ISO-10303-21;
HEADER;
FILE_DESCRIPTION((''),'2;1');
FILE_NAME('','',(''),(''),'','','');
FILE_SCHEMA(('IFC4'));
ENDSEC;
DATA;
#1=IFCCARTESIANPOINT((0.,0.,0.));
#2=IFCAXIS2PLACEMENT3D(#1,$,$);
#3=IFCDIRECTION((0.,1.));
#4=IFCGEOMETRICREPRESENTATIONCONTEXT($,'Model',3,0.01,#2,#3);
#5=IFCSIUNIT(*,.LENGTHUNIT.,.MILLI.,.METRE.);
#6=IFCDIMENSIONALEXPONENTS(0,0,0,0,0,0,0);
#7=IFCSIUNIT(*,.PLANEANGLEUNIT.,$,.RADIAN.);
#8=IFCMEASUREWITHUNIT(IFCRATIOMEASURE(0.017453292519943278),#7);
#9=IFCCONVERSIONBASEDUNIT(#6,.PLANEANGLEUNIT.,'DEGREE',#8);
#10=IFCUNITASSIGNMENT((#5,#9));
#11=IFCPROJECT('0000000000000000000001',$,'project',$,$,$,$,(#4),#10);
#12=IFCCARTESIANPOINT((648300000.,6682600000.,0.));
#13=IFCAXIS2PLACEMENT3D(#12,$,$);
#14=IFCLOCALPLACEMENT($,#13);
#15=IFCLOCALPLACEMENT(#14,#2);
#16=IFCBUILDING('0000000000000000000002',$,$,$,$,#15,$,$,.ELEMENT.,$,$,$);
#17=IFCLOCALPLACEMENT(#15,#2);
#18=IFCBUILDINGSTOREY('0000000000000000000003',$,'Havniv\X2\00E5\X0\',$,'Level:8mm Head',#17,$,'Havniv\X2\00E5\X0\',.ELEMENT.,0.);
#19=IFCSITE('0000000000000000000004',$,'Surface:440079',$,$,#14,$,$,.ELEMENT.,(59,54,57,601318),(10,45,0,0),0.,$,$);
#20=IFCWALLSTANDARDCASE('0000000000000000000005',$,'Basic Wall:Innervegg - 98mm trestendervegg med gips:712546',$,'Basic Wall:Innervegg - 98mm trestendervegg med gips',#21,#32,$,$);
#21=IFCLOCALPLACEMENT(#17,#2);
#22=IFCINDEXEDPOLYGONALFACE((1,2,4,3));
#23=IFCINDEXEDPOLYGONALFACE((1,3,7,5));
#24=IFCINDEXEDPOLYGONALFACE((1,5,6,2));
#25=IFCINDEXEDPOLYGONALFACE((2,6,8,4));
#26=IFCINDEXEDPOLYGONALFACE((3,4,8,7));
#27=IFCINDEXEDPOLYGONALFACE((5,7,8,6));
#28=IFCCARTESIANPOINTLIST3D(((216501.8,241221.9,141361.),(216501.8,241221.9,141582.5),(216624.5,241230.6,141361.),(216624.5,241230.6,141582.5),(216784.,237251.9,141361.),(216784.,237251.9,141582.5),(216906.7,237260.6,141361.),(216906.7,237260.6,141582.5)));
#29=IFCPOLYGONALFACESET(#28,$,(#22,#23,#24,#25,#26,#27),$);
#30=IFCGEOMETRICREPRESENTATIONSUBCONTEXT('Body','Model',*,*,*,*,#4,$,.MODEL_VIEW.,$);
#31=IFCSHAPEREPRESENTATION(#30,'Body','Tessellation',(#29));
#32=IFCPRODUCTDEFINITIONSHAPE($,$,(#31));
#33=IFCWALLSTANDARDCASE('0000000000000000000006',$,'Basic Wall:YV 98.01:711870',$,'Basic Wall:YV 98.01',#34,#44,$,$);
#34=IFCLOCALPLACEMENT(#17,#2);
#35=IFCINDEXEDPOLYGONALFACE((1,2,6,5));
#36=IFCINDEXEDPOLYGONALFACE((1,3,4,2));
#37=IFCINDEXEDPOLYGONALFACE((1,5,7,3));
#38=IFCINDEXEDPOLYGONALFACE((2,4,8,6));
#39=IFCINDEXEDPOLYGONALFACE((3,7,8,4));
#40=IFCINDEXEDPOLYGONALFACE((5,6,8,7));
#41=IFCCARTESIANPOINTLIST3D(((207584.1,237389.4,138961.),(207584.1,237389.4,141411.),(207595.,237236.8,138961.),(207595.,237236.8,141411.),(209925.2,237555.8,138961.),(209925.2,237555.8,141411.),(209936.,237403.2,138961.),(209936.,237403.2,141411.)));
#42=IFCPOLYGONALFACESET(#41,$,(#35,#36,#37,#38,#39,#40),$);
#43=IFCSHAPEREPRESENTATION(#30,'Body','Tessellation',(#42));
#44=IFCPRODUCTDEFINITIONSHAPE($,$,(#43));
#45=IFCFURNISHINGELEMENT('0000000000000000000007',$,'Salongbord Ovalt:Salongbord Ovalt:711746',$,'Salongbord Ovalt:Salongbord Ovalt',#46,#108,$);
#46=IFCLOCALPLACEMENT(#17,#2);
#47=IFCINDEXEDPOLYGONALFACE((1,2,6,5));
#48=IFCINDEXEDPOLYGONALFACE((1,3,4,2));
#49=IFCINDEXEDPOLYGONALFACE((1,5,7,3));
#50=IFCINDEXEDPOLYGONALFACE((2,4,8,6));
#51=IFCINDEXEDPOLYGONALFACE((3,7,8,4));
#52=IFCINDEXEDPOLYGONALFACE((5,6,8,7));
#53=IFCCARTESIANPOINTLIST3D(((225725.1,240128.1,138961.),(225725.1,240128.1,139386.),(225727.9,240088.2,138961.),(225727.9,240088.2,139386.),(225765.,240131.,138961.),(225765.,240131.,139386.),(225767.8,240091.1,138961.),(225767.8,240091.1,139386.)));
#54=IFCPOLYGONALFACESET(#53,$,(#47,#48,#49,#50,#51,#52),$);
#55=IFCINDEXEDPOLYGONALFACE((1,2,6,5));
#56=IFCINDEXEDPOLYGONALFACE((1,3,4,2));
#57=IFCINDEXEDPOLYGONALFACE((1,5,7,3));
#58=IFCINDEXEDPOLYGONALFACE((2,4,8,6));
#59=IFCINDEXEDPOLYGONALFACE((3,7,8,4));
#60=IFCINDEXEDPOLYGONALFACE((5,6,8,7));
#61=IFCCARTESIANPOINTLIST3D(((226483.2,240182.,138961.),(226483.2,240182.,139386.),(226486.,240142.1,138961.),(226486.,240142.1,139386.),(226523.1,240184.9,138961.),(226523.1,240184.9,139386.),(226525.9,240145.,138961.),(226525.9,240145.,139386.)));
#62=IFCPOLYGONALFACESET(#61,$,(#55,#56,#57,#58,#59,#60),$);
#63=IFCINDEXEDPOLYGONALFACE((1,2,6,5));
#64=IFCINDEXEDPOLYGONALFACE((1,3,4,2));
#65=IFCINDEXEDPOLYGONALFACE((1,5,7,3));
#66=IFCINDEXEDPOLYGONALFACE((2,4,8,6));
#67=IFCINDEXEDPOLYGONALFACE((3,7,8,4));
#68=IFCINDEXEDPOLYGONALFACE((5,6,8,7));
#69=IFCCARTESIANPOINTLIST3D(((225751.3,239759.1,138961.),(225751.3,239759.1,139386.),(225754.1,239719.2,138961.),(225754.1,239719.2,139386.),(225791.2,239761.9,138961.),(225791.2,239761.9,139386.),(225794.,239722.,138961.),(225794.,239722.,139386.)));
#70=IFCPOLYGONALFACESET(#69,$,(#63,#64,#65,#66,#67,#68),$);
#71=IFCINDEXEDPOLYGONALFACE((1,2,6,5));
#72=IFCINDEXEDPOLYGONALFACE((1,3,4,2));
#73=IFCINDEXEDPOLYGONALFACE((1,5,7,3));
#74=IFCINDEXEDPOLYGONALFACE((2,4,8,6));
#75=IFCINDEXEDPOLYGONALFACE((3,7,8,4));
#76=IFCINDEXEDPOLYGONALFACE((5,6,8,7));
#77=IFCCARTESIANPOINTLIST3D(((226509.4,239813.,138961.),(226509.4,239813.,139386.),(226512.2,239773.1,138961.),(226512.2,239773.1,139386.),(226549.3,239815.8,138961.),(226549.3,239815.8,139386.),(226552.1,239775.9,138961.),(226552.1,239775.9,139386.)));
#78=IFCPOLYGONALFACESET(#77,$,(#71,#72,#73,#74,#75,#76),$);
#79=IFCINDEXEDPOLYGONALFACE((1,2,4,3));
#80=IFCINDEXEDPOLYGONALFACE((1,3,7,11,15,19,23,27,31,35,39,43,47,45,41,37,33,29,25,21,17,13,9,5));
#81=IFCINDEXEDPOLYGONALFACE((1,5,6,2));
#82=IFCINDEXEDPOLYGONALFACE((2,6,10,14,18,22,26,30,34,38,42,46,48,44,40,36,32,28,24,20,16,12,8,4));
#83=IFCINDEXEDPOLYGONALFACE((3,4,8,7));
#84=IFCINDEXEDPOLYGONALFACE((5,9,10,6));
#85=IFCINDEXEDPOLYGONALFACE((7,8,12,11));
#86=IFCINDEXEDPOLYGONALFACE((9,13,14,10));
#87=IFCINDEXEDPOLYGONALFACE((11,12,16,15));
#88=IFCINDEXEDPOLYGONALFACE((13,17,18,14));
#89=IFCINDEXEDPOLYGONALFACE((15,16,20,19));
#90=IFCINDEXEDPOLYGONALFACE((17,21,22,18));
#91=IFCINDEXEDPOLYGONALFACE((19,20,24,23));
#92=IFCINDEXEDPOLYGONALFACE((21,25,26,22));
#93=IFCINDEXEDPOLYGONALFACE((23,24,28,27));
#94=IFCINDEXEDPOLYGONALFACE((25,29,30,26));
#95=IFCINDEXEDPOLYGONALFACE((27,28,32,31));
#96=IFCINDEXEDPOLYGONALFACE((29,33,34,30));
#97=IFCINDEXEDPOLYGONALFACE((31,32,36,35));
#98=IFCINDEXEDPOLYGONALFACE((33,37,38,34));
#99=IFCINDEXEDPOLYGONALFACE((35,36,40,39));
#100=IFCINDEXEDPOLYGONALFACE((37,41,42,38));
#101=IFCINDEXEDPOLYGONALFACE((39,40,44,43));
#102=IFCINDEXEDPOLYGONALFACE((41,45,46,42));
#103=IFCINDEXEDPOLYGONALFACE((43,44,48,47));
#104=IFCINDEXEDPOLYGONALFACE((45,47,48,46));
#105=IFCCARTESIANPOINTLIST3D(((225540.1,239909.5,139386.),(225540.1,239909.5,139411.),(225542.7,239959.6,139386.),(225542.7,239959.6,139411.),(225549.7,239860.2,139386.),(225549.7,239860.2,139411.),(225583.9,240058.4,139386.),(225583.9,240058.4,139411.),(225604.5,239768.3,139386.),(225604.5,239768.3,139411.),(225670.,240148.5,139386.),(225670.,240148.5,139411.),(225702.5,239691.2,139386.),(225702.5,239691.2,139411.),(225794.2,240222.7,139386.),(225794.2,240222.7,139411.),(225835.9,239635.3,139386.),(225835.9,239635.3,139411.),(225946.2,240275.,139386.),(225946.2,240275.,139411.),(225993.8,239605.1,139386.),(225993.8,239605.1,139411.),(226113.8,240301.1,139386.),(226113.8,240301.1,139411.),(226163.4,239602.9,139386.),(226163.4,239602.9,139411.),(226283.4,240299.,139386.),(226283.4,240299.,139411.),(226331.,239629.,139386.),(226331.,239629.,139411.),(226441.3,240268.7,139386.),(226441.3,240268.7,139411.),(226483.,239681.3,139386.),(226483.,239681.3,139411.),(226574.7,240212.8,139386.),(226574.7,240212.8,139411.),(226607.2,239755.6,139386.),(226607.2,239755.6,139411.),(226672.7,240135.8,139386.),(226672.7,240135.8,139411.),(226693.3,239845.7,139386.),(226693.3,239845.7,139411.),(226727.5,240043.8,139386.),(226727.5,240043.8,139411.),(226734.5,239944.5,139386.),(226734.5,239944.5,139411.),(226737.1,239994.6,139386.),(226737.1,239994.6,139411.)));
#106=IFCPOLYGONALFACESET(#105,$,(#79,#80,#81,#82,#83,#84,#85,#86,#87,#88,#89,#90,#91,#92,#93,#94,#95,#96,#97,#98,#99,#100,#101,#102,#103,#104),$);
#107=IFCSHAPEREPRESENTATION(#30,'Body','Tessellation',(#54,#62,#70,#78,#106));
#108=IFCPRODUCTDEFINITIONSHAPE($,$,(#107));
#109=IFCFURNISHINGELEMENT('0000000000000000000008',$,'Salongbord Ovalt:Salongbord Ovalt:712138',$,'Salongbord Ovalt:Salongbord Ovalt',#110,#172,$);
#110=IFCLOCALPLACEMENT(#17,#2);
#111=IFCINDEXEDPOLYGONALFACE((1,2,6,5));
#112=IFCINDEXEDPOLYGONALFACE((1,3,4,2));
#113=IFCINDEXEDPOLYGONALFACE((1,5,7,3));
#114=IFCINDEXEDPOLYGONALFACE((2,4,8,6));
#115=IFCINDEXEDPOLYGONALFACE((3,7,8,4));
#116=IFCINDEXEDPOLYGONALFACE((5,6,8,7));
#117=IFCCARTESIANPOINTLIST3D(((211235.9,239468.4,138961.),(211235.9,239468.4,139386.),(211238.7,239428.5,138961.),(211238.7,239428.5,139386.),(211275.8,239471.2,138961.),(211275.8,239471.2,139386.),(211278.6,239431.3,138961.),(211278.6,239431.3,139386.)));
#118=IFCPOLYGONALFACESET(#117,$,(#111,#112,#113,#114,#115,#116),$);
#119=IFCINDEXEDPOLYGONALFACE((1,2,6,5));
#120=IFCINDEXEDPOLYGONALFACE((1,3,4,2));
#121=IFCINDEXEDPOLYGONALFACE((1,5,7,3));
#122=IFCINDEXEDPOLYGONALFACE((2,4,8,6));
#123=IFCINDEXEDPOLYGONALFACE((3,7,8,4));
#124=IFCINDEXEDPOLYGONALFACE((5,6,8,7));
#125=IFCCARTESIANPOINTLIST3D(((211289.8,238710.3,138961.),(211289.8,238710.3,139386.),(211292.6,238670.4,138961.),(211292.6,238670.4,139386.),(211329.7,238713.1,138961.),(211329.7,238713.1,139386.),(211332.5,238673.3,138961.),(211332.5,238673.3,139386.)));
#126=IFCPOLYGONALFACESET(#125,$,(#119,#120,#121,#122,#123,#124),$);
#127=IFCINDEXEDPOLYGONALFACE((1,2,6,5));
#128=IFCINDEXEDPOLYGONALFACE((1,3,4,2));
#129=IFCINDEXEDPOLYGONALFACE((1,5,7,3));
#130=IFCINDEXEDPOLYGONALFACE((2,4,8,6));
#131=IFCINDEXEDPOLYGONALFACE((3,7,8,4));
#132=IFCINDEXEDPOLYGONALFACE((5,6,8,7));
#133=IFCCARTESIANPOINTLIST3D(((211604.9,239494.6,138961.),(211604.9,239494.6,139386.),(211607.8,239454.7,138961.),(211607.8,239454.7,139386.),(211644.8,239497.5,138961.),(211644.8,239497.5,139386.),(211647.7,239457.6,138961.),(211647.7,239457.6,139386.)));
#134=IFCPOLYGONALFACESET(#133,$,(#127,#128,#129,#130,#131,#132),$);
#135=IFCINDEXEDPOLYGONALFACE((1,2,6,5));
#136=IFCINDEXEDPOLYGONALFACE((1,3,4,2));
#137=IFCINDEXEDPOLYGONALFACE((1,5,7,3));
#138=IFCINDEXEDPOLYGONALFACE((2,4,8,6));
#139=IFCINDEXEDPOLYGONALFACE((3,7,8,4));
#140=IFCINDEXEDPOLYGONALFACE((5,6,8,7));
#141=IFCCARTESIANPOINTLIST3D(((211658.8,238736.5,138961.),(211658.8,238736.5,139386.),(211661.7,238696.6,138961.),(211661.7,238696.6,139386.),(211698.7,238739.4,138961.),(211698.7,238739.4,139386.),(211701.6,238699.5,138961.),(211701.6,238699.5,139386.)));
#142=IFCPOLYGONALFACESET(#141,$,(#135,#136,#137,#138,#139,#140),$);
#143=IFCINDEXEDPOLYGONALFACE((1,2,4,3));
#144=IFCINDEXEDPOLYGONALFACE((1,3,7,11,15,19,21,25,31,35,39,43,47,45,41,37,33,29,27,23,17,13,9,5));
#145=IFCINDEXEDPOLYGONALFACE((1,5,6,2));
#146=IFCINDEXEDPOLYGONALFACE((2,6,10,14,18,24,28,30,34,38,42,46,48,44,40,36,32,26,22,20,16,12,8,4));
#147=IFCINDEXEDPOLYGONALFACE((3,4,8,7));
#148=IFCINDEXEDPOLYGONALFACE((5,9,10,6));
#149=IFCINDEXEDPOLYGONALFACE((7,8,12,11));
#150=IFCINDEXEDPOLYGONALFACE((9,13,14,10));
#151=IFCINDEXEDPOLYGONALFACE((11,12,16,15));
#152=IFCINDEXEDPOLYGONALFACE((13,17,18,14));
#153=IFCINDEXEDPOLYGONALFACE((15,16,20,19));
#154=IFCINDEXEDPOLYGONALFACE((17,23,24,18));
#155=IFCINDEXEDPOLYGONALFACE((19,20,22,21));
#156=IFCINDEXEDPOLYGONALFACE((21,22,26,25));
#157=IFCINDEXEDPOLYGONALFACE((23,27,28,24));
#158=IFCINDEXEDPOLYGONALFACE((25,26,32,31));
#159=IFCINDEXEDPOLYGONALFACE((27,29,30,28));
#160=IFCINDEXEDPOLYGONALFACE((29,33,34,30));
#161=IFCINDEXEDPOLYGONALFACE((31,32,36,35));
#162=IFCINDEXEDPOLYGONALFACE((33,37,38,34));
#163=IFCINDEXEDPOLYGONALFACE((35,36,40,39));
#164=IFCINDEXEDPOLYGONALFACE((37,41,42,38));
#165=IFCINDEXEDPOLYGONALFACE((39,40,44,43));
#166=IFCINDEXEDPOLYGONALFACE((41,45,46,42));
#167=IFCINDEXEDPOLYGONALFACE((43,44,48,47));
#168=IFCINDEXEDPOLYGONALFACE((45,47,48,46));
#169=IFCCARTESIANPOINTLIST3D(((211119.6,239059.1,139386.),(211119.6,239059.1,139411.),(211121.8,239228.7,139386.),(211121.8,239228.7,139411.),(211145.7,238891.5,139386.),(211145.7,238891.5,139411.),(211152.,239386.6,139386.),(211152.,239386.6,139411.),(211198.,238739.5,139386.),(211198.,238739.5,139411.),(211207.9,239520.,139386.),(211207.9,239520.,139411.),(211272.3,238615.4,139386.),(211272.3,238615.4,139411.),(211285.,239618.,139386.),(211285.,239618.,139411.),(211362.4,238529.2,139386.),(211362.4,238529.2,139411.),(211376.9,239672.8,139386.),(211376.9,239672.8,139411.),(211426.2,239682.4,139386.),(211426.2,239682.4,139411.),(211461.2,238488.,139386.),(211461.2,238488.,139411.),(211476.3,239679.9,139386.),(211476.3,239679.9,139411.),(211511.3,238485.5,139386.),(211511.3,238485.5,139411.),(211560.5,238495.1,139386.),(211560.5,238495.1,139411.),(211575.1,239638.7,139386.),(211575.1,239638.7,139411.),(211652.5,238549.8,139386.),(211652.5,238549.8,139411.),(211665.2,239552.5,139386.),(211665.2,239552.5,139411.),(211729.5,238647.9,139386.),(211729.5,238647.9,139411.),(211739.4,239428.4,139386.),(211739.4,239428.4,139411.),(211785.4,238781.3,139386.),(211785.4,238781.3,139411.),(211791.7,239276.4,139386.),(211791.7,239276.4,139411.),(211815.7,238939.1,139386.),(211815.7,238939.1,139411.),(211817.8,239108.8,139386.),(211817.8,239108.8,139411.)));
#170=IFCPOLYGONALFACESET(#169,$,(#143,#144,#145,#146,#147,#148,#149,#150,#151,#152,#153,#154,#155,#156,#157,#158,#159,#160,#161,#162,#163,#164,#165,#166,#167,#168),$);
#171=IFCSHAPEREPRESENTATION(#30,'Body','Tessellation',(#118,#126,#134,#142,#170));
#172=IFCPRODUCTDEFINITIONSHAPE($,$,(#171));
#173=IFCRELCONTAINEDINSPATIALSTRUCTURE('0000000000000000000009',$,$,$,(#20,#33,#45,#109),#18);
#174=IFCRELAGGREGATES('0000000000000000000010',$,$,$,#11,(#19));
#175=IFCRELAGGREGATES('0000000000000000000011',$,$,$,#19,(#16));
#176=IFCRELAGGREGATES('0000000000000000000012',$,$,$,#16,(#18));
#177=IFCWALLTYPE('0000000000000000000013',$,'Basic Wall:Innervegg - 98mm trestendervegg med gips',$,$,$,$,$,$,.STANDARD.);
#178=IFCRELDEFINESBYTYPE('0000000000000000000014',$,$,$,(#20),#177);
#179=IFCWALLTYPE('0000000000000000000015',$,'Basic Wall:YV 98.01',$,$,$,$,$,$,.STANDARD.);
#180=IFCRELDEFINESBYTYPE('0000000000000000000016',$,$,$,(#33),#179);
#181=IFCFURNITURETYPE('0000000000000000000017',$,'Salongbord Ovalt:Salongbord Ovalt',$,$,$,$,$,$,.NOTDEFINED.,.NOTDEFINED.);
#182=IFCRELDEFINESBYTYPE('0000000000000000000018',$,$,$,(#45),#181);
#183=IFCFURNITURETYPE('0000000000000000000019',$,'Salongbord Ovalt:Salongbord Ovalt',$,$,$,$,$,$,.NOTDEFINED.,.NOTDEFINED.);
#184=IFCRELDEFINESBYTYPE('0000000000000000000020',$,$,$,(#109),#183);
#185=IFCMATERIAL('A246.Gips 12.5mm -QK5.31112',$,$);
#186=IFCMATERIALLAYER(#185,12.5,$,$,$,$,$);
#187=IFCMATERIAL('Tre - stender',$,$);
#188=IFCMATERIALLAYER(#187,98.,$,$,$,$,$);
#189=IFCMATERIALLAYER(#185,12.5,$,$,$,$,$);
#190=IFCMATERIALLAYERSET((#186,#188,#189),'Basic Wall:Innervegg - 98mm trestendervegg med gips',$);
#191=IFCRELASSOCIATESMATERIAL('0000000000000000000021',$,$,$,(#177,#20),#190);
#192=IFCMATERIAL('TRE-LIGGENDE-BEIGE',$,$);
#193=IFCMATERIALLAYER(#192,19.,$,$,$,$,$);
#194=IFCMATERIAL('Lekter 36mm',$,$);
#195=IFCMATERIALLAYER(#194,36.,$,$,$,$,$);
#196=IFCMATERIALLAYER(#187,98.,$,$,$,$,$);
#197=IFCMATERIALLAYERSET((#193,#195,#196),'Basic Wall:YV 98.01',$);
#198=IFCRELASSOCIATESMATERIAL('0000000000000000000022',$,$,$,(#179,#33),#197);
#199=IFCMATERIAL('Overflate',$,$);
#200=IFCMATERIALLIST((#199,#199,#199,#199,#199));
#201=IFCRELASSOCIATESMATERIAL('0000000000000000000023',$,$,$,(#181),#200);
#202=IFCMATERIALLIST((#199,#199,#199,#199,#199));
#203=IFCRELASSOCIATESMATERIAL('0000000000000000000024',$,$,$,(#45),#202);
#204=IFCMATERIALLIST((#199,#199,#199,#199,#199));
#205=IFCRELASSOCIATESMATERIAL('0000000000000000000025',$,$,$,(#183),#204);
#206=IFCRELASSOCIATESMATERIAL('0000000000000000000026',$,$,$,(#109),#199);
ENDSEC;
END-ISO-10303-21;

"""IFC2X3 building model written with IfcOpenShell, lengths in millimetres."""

from ifc_helpers import new_model, entity, si_unit, converted_unit, direction, frame, frame_2d, origin, origin_2d_with_axis, place, context, subcontext, project, spatial, polyline, rectangle, outline, extrude, clip, bounded_halfspace, source, transform, mapped, material, material_list, layer, layer_set, layer_usage, type_object, type_shapes, element, save


model = new_model("IFC2X3")

# Units and contexts
model_context = context("Model", 3, precision=0.01, world=origin(), true_north=direction((0.0, 1.0)))
body_context = subcontext(model_context, "Body", "Model", "MODEL_VIEW")
ifc_project = project(units=[si_unit("LENGTHUNIT", "METRE", prefix="MILLI"), converted_unit("PLANEANGLEUNIT", "DEGREE", entity("IfcRatioMeasure", 0.017453292519943278), si_unit("PLANEANGLEUNIT", "RADIAN"), dimensions=[0, 0, 0, 0, 0, 0, 0])], contexts=[model_context])

# Site, building, storey
site_placement = place(None, frame((648300000.0, 6682600000.0, 0.0)))
site = spatial("IfcSite", under=ifc_project, at=site_placement, Name="Surface:440079", CompositionType="ELEMENT", RefLatitude=(59, 54, 57, 601318), RefLongitude=(10, 45, 0, 0), RefElevation=0.0)
building_placement = place(site_placement, origin())
building = spatial("IfcBuilding", under=site, at=building_placement, CompositionType="ELEMENT")
storey_placement = place(building_placement, origin())
storey = spatial("IfcBuildingStorey", under=building, at=storey_placement, Name="Havnivå", ObjectType="Level:8mm Head", LongName="Havnivå", CompositionType="ELEMENT", Elevation=0.0)

# Shared definitions
ifc_material_1 = material(Name="TRE-LIGGENDE-BEIGE")
ifc_material_2 = material(Name="Lekter 36mm")

# Wall
ifc_material_3 = material(Name="A246.Gips 12.5mm -QK5.31112")
ifc_layer_1 = layer(ifc_material_3, 12.5)
ifc_material_4 = material(Name="Tre - stender")
ifc_layer_2 = layer(ifc_material_4, 98.0)
ifc_layer_3 = layer(ifc_material_3, 12.5)
ifc_layer_set_1 = layer_set([ifc_layer_1, ifc_layer_2, ifc_layer_3], Name="Basic Wall:Innervegg - 98mm trestendervegg med gips")
ifc_layer_usage_1 = layer_usage(ifc_layer_set_1, "AXIS2", "NEGATIVE", 61.5)
wall_type_1 = type_object("IfcWallType", Name="Basic Wall:Innervegg - 98mm trestendervegg med gips", PredefinedType="STANDARD", material=ifc_layer_set_1)
wall_1_placement = place(storey_placement, frame((216845.4, 237256.3, 141361.0), z_axis=(0.0, 0.0, 1.0), x_axis=(-0.070908, 0.997483, 0.0)))
element("IfcWallStandardCase", 1, at=wall_1_placement, inside=storey, type_object=wall_type_1, material=ifc_layer_usage_1, Name="Basic Wall:Innervegg - 98mm trestendervegg med gips:712546", ObjectType="Basic Wall:Innervegg - 98mm trestendervegg med gips", context=body_context, shape_type="Clipping", body=[
    clip(extrude(rectangle(XDim=3980.0, YDim=123.0, at=frame_2d((1990.0, 0.0), x_axis=(-1.0, 0.0))), origin(), (0.0, 0.0, 1.0), 221.5), bounded_halfspace(frame((0.0, -61.5, 221.5), z_axis=(0.0, 0.0, -1.0), x_axis=(0.0, 1.0, 0.0)), True, frame((0.0, -61.5, 221.5)), polyline([(0.0, 0.0), (1213104.0, 0.0), (1213104.0, 37490.4), (0.0, 37490.4), (0.0, 0.0)]))),
])

# Shared definitions
ifc_layer_4 = layer(ifc_material_1, 19.0)
ifc_layer_5 = layer(ifc_material_2, 36.0)
ifc_layer_6 = layer(ifc_material_4, 98.0)
ifc_layer_set_2 = layer_set([ifc_layer_4, ifc_layer_5, ifc_layer_6], Name="Basic Wall:YV 98.01")
wall_type_2 = type_object("IfcWallType", Name="Basic Wall:YV 98.01", PredefinedType="STANDARD", material=ifc_layer_set_2)

# Wall
ifc_layer_usage_2 = layer_usage(ifc_layer_set_2, "AXIS2", "NEGATIVE", 76.5)
wall_2_placement = place(storey_placement, frame((209930.6, 237479.5, 138961.0), z_axis=(0.0, 0.0, 1.0), x_axis=(-0.997483, -0.070908, 0.0)))
element("IfcWallStandardCase", 2, at=wall_2_placement, inside=storey, type_object=wall_type_2, material=ifc_layer_usage_2, Name="Basic Wall:YV 98.01:711870", ObjectType="Basic Wall:YV 98.01", context=body_context, shape_type="SweptSolid", body=[
    extrude(rectangle(XDim=2347.0, YDim=153.0, at=frame_2d((1173.5, 0.0), x_axis=(-1.0, 0.0))), origin(), (0.0, 0.0, 1.0), 2450.0),
])

# Furnishing elements
ifc_material_5 = material(Name="Overflate")
ifc_material_list_1 = material_list([ifc_material_5, ifc_material_5, ifc_material_5, ifc_material_5, ifc_material_5])
ifc_material_list_2 = material_list([ifc_material_5, ifc_material_5, ifc_material_5, ifc_material_5, ifc_material_5])
furniture_type_1 = type_object("IfcFurnitureType", Name="Salongbord Ovalt:Salongbord Ovalt", material=ifc_material_list_2)
shared_shape_1 = source(origin(), body_context, "Body", "SweptSolid", [
    extrude(rectangle(XDim=40.0, YDim=40.0, at=origin_2d_with_axis()), frame((380.0, -185.0, 0.0), z_axis=(0.0, 0.0, 1.0), x_axis=(0.0, 1.0, 0.0)), (0.0, 0.0, 1.0), 425.0),
    extrude(rectangle(XDim=40.0, YDim=40.0, at=origin_2d_with_axis()), frame((-380.0, -185.0, 0.0), z_axis=(0.0, 0.0, 1.0), x_axis=(0.0, 1.0, 0.0)), (0.0, 0.0, 1.0), 425.0),
    extrude(rectangle(XDim=40.0, YDim=40.0, at=origin_2d_with_axis()), frame((380.0, 185.0, 0.0), z_axis=(0.0, 0.0, 1.0), x_axis=(0.0, 1.0, 0.0)), (0.0, 0.0, 1.0), 425.0),
    extrude(rectangle(XDim=40.0, YDim=40.0, at=origin_2d_with_axis()), frame((-380.0, 185.0, 0.0), z_axis=(0.0, 0.0, 1.0), x_axis=(0.0, 1.0, 0.0)), (0.0, 0.0, 1.0), 425.0),
    extrude(outline(polyline([(-73.0, -595.5), (-22.8, -595.5), (77.9, -559.4), (172.3, -478.0), (252.8, -357.8), (312.8, -208.7), (347.4, -42.6), (353.9, 126.9), (331.7, 286.1), (282.7, 422.2), (210.7, 524.0), (121.7, 583.4), (73.0, 595.5), (22.8, 595.5), (-77.9, 559.4), (-172.3, 478.0), (-252.8, 357.8), (-312.8, 208.7), (-347.4, 42.6), (-353.9, -126.9), (-331.7, -286.1), (-282.7, -422.2), (-210.7, -524.0), (-121.7, -583.4), (-73.0, -595.5)])), frame((0.0, 0.0, 425.0), z_axis=(0.0, 0.0, 1.0), x_axis=(0.121697, -0.992567, 0.0)), (0.0, 0.0, 1.0), 25.0),
])
type_shapes(furniture_type_1, [shared_shape_1])
furnishing_1_placement = place(storey_placement, frame((226138.6, 239952.0, 138961.0), z_axis=(0.0, 0.0, 1.0), x_axis=(-0.997483, -0.070908, 0.0)))
element("IfcFurnishingElement", 3, at=furnishing_1_placement, inside=storey, type_object=furniture_type_1, material=ifc_material_list_1, Name="Salongbord Ovalt:Salongbord Ovalt:711746", ObjectType="Salongbord Ovalt:Salongbord Ovalt", context=body_context, shape_type="MappedRepresentation", body=[
    mapped(shared_shape_1, transform((0.0, 0.0, 0.0), scale=1.0)),
])
ifc_material_list_3 = material_list([ifc_material_5, ifc_material_5, ifc_material_5, ifc_material_5, ifc_material_5])
furniture_type_2 = type_object("IfcFurnitureType", Name="Salongbord Ovalt:Salongbord Ovalt", material=ifc_material_list_3)
shared_shape_2 = source(origin(), body_context, "Body", "SweptSolid", [
    extrude(rectangle(XDim=40.0, YDim=40.0, at=origin_2d_with_axis()), frame((380.0, 185.0, 0.0), z_axis=(0.0, 0.0, 1.0), x_axis=(-1.0, 0.0, 0.0)), (0.0, 0.0, 1.0), 425.0),
    extrude(rectangle(XDim=40.0, YDim=40.0, at=origin_2d_with_axis()), frame((-380.0, 185.0, 0.0), z_axis=(0.0, 0.0, 1.0), x_axis=(-1.0, 0.0, 0.0)), (0.0, 0.0, 1.0), 425.0),
    extrude(rectangle(XDim=40.0, YDim=40.0, at=origin_2d_with_axis()), frame((380.0, -185.0, 0.0), z_axis=(0.0, 0.0, 1.0), x_axis=(-1.0, 0.0, 0.0)), (0.0, 0.0, 1.0), 425.0),
    extrude(rectangle(XDim=40.0, YDim=40.0, at=origin_2d_with_axis()), frame((-380.0, -185.0, 0.0), z_axis=(0.0, 0.0, 1.0), x_axis=(-1.0, 0.0, 0.0)), (0.0, 0.0, 1.0), 425.0),
    extrude(outline(polyline([(-73.0, -595.5), (-22.8, -595.5), (77.9, -559.4), (172.3, -478.0), (252.8, -357.8), (312.8, -208.7), (347.4, -42.6), (353.9, 126.9), (331.7, 286.1), (282.7, 422.2), (210.7, 524.0), (121.7, 583.4), (73.0, 595.5), (22.8, 595.5), (-77.9, 559.4), (-172.3, 478.0), (-252.8, 357.8), (-312.8, 208.7), (-347.4, 42.6), (-353.9, -126.9), (-331.7, -286.1), (-282.7, -422.2), (-210.7, -524.0), (-121.7, -583.4), (-73.0, -595.5)])), frame((0.0, 0.0, 425.0), z_axis=(0.0, 0.0, 1.0), x_axis=(0.121697, -0.992567, 0.0)), (0.0, 0.0, 1.0), 25.0),
])
type_shapes(furniture_type_2, [shared_shape_2])
for number, where, z_axis, x_axis, name in (
    (4, (211468.7, 239083.9, 138961.0), (0.0, 0.0, 1.0), (-0.070908, 0.997483, 0.0), "Salongbord Ovalt:Salongbord Ovalt:712138"),
):
    element("IfcFurnishingElement", number, at=place(storey_placement, frame(where, z_axis=z_axis, x_axis=x_axis)), inside=storey, type_object=furniture_type_2, material=ifc_material_5, Name=name, ObjectType="Salongbord Ovalt:Salongbord Ovalt", context=body_context, shape_type="MappedRepresentation", body=[
        mapped(shared_shape_2, transform((0.0, 0.0, 0.0), scale=1.0)),
    ])

save(model, "model.ifc")
